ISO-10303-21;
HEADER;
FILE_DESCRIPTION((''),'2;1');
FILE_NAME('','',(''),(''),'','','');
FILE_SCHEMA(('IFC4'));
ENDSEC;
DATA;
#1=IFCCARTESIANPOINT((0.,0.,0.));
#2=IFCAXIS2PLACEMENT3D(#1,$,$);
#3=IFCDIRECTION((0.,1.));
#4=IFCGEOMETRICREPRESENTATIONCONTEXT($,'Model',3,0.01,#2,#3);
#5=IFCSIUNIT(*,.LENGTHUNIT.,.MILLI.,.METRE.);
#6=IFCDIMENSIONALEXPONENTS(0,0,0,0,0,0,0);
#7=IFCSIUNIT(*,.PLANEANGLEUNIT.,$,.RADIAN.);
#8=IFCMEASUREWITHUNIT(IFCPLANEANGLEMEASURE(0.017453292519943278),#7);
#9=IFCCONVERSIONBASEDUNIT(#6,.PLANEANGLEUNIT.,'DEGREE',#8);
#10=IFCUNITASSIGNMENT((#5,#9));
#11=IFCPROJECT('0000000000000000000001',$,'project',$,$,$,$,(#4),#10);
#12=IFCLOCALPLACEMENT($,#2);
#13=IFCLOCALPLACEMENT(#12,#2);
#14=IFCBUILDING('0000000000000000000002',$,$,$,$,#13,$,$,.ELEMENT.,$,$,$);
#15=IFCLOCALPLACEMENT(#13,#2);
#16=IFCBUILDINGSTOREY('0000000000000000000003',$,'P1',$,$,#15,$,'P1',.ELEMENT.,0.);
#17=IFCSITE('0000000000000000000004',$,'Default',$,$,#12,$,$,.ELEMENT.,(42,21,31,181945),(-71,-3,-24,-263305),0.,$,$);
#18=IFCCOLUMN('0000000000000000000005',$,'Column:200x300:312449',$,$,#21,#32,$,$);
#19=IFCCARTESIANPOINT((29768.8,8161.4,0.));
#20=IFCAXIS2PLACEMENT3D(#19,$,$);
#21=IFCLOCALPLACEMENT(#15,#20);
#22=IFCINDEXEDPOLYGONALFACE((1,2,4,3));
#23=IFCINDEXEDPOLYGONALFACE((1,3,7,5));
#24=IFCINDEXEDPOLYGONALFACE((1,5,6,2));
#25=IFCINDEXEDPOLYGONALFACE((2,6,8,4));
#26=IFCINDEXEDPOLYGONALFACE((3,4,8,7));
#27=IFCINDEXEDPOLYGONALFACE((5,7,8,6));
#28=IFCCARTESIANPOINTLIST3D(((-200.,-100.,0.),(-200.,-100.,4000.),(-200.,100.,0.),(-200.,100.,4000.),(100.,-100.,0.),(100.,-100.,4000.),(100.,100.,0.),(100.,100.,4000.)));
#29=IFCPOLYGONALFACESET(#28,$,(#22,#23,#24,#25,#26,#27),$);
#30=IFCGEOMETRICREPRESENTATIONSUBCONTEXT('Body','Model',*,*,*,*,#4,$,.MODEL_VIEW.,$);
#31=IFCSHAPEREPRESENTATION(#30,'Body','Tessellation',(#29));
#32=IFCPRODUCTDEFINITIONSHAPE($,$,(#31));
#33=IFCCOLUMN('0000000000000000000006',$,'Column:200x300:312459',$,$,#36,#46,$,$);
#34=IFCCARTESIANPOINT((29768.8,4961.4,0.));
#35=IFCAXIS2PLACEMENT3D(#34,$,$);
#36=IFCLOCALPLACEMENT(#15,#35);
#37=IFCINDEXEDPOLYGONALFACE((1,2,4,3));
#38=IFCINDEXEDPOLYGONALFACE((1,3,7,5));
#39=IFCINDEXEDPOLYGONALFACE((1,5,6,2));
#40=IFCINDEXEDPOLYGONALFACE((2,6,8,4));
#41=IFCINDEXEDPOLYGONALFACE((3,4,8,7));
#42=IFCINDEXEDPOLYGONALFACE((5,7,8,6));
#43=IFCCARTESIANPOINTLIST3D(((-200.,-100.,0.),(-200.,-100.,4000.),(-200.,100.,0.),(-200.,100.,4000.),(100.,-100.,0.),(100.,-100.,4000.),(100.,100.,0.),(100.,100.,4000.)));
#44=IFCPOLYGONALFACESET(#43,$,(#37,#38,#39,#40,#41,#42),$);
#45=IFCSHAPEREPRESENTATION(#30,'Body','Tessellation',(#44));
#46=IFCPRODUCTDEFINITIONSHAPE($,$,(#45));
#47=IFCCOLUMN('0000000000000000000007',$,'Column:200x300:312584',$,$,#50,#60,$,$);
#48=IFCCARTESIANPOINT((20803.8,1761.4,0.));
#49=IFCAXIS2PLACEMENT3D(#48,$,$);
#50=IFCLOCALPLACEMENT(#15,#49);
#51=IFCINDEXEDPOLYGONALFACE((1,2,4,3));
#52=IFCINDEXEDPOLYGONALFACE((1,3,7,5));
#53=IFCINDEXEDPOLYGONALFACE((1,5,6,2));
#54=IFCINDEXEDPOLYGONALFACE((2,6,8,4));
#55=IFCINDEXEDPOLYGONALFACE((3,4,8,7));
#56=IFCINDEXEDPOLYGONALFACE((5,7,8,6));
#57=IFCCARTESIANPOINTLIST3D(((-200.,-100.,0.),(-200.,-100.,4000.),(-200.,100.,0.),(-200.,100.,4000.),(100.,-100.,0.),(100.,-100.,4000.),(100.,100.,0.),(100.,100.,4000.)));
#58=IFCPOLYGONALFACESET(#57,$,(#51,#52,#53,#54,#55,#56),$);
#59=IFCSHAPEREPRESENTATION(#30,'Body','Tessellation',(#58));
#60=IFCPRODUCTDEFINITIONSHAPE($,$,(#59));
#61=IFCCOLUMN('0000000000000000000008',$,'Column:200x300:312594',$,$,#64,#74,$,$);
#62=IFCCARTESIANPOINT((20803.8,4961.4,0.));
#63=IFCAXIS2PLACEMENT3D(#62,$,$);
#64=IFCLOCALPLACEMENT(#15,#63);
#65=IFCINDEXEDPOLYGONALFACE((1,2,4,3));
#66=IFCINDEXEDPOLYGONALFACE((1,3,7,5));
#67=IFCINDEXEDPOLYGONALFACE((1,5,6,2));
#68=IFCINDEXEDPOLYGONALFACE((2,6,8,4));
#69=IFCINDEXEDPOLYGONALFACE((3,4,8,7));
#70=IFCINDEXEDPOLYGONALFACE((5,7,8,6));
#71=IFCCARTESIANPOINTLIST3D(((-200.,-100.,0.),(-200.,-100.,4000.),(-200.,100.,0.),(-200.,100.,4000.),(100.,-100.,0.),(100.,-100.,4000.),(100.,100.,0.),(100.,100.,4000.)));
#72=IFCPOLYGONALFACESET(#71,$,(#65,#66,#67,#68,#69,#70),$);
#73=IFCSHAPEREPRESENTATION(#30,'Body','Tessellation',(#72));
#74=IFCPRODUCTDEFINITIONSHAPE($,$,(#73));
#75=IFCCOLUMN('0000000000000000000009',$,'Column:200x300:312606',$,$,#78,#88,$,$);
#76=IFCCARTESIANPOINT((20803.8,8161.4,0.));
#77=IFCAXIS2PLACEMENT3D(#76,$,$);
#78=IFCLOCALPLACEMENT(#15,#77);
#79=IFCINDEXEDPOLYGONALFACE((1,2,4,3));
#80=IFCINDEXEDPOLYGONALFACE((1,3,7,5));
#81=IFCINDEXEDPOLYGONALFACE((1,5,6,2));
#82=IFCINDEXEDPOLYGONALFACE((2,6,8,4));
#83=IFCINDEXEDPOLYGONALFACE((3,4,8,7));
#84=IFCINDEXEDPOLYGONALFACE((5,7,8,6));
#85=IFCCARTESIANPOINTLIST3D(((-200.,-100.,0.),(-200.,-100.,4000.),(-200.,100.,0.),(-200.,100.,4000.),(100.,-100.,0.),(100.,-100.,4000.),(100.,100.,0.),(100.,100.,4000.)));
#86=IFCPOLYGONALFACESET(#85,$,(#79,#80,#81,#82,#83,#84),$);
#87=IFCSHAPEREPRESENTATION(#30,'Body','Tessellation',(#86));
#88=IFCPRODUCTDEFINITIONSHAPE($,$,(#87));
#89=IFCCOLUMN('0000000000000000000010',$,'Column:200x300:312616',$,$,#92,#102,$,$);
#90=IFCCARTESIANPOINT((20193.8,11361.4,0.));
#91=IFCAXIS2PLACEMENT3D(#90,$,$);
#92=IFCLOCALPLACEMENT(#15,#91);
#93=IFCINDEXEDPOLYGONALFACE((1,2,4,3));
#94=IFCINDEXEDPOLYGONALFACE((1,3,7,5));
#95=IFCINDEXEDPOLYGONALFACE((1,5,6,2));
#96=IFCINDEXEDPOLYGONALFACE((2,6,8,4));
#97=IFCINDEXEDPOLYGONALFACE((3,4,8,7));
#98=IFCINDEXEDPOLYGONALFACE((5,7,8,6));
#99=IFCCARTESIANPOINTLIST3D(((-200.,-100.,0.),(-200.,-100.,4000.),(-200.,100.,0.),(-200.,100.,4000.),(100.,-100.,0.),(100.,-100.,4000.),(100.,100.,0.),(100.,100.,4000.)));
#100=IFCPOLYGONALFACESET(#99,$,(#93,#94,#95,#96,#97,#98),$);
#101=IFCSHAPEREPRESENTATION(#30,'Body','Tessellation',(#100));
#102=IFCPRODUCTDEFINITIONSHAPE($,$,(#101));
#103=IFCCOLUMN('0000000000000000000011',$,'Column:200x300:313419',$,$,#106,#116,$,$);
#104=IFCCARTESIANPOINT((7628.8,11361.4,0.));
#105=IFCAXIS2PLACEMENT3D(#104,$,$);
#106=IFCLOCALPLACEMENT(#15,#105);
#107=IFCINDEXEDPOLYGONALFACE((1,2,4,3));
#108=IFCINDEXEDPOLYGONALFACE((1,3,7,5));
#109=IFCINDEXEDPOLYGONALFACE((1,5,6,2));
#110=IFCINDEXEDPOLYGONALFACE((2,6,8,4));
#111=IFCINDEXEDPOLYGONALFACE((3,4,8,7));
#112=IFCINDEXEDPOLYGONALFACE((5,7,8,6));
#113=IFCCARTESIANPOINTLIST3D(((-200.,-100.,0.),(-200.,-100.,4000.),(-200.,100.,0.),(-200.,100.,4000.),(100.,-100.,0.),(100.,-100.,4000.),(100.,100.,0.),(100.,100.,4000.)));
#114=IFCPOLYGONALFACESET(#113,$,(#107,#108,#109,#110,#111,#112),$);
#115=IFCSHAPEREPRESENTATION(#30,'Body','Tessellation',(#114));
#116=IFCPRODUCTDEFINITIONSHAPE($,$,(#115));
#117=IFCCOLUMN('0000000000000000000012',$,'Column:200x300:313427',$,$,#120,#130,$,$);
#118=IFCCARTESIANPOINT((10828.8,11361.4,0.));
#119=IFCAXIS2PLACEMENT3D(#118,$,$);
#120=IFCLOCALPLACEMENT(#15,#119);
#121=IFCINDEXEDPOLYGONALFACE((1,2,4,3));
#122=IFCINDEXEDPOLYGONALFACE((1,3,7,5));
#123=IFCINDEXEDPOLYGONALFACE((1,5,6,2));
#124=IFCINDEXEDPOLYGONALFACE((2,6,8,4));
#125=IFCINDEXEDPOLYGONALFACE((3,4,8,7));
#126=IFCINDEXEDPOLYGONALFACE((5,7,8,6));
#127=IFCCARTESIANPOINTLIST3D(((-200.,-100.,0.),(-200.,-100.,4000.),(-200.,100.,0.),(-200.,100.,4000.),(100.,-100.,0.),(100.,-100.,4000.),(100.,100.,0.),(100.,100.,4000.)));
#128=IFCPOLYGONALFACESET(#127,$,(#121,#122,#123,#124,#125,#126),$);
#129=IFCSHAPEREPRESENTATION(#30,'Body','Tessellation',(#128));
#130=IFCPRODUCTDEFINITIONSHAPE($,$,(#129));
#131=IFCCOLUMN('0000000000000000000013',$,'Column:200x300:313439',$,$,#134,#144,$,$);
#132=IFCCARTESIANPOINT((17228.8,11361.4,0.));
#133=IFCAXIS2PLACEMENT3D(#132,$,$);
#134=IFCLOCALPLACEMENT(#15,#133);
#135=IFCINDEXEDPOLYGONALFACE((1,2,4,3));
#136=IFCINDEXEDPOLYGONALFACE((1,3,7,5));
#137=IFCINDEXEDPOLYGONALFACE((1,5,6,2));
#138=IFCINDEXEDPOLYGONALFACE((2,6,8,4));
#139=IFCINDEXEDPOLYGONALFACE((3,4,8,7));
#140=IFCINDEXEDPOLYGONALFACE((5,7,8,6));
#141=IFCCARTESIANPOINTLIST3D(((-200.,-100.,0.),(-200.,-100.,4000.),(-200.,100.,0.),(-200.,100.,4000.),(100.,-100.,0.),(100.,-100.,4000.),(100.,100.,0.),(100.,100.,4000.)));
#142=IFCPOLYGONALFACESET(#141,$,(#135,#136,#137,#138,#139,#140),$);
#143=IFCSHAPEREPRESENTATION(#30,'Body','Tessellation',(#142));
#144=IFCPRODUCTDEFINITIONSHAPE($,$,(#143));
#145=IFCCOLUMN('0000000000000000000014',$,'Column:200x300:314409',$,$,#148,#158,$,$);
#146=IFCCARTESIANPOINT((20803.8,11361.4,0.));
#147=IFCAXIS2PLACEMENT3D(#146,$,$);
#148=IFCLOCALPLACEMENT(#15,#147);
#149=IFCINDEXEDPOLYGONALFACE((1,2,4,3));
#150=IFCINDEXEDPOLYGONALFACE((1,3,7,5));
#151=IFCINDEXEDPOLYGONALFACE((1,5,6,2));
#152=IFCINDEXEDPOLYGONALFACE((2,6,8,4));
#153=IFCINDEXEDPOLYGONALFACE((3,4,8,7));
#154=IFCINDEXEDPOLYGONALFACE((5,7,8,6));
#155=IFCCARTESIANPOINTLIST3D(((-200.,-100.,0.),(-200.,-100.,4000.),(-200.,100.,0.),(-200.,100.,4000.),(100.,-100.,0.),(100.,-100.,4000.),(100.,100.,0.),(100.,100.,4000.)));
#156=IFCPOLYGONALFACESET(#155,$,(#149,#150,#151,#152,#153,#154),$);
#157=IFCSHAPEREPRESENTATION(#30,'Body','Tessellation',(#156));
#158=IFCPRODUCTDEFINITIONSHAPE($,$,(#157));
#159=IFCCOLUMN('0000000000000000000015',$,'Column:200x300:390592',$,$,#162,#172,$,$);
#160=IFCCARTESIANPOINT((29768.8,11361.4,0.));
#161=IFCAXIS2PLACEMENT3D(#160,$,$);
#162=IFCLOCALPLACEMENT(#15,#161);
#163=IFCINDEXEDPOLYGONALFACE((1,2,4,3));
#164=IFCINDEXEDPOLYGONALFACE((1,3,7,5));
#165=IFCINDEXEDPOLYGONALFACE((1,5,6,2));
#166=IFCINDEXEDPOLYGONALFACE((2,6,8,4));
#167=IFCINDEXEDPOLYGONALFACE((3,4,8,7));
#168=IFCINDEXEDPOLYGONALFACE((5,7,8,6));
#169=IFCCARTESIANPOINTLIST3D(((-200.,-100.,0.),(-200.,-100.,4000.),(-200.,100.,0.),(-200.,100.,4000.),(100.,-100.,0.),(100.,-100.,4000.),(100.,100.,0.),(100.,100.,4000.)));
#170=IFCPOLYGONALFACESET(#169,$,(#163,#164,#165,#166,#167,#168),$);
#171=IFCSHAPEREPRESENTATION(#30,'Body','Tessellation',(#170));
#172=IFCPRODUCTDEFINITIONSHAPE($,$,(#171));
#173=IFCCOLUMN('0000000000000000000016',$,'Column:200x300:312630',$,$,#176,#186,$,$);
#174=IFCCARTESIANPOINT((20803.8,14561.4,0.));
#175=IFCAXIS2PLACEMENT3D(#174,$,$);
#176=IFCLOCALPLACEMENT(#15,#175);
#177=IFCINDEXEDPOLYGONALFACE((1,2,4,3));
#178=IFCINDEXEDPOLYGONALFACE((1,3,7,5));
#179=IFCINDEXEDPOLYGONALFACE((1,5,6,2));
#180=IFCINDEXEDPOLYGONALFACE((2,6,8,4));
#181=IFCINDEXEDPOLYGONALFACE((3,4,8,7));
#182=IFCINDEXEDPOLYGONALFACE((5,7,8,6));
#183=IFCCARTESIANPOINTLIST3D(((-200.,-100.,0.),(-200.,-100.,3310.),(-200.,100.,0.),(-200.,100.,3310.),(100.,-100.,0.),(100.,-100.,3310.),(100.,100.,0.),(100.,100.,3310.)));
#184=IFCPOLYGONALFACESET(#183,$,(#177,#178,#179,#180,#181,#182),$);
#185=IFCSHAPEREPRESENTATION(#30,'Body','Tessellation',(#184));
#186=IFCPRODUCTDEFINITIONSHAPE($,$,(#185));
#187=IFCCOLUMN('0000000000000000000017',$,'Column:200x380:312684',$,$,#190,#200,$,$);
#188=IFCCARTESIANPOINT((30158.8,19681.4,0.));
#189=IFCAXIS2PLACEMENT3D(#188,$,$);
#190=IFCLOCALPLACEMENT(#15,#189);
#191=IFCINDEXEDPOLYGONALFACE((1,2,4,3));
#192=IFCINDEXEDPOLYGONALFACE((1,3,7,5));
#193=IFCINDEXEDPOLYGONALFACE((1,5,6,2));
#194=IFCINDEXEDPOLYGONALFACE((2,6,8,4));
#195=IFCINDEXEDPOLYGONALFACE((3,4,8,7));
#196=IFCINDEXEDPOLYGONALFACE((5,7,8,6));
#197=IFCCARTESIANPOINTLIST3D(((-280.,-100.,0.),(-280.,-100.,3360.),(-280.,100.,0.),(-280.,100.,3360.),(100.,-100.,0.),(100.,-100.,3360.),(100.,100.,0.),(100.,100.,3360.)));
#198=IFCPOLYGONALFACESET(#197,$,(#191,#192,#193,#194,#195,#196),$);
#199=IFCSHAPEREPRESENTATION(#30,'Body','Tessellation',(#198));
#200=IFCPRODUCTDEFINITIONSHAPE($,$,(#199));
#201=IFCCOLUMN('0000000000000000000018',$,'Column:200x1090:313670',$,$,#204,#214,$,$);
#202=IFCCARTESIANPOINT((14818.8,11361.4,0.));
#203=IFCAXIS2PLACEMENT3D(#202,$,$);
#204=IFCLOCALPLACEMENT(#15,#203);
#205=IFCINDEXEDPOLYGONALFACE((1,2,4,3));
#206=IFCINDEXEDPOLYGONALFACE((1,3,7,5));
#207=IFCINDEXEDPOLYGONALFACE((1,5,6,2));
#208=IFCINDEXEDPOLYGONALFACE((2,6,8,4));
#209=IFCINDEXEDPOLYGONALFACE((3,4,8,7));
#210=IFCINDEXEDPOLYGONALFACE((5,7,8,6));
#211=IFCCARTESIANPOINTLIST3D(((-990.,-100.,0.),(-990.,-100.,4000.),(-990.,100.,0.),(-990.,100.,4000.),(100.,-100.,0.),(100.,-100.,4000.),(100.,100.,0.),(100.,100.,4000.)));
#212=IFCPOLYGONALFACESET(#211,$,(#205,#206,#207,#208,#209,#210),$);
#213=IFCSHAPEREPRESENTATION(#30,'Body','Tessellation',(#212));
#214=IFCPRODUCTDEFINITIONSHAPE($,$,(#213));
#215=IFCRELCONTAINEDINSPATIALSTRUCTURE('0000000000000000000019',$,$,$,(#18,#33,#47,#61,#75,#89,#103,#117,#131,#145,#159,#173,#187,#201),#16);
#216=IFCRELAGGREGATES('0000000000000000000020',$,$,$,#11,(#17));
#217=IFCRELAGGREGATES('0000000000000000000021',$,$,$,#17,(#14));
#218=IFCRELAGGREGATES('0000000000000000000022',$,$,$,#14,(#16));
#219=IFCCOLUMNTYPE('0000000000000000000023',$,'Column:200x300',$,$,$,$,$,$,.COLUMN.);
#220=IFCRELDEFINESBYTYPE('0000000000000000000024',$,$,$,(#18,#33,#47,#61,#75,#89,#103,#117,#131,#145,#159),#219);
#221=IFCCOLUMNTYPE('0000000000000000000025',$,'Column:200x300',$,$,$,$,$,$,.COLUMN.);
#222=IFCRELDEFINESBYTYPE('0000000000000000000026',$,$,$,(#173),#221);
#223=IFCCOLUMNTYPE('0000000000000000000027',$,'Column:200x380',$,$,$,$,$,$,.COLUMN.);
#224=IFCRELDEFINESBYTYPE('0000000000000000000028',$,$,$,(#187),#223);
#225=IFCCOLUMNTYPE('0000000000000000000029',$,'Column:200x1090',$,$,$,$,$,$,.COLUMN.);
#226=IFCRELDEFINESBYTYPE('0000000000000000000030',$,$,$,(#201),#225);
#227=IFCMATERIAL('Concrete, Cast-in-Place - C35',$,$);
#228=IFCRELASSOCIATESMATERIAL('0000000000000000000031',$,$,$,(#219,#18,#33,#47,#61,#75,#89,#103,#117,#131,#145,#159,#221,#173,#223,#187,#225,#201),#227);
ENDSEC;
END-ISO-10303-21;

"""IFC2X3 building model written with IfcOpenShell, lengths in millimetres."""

from ifc_helpers import new_model, entity, si_unit, converted_unit, direction, frame, origin, origin_2d_with_axis, place, context, subcontext, project, spatial, rectangle, extrude, source, transform, mapped, material, type_object, type_shapes, element, save


model = new_model("IFC2X3")

# Units and contexts
model_context = context("Model", 3, precision=0.01, world=origin(), true_north=direction((0.0, 1.0)))
body_context = subcontext(model_context, "Body", "Model", "MODEL_VIEW")
ifc_project = project(units=[si_unit("LENGTHUNIT", "METRE", prefix="MILLI"), converted_unit("PLANEANGLEUNIT", "DEGREE", entity("IfcPlaneAngleMeasure", 0.017453292519943278), si_unit("PLANEANGLEUNIT", "RADIAN"), dimensions=[0, 0, 0, 0, 0, 0, 0])], contexts=[model_context])

# Site, building, storey
site_placement = place(None, origin())
site = spatial("IfcSite", under=ifc_project, at=site_placement, Name="Default", CompositionType="ELEMENT", RefLatitude=(42, 21, 31, 181945), RefLongitude=(-71, -3, -24, -263305), RefElevation=0.0)
building_placement = place(site_placement, origin())
building = spatial("IfcBuilding", under=site, at=building_placement, CompositionType="ELEMENT")
storey_placement = place(building_placement, origin())
storey = spatial("IfcBuildingStorey", under=building, at=storey_placement, Name="P1", LongName="P1", CompositionType="ELEMENT", Elevation=0.0)

# Columns
ifc_material = material(Name="Concrete, Cast-in-Place - C35")
column_type_1 = type_object("IfcColumnType", Name="Column:200x300", PredefinedType="COLUMN", material=ifc_material)
shared_shape_1 = source(origin(), body_context, "Body", "SweptSolid", [
    extrude(rectangle(XDim=300.0, YDim=200.0, at=origin_2d_with_axis()), frame((-50.0, 0.0, 0.0), z_axis=(0.0, 0.0, 1.0), x_axis=(-1.0, 0.0, 0.0)), (0.0, 0.0, 1.0), 4000.0),
])
type_shapes(column_type_1, [shared_shape_1])
for number, where, name in (
    (1, (29768.8, 8161.4, 0.0), "Column:200x300:312449"),
    (2, (29768.8, 4961.4, 0.0), "Column:200x300:312459"),
    (3, (20803.8, 1761.4, 0.0), "Column:200x300:312584"),
    (4, (20803.8, 4961.4, 0.0), "Column:200x300:312594"),
    (5, (20803.8, 8161.4, 0.0), "Column:200x300:312606"),
    (6, (20193.8, 11361.4, 0.0), "Column:200x300:312616"),
    (7, (7628.8, 11361.4, 0.0), "Column:200x300:313419"),
    (8, (10828.8, 11361.4, 0.0), "Column:200x300:313427"),
    (9, (17228.8, 11361.4, 0.0), "Column:200x300:313439"),
    (10, (20803.8, 11361.4, 0.0), "Column:200x300:314409"),
    (11, (29768.8, 11361.4, 0.0), "Column:200x300:390592"),
):
    element("IfcColumn", number, at=place(storey_placement, frame(where)), inside=storey, type_object=column_type_1, material=ifc_material, Name=name, context=body_context, shape_type="MappedRepresentation", body=[
        mapped(shared_shape_1, transform((0.0, 0.0, 0.0), scale=1.0)),
    ])
column_type_2 = type_object("IfcColumnType", Name="Column:200x300", PredefinedType="COLUMN", material=ifc_material)
shared_shape_2 = source(origin(), body_context, "Body", "SweptSolid", [
    extrude(rectangle(XDim=300.0, YDim=200.0, at=origin_2d_with_axis()), frame((-50.0, 0.0, 0.0), z_axis=(0.0, 0.0, 1.0), x_axis=(-1.0, 0.0, 0.0)), (0.0, 0.0, 1.0), 3310.0),
])
type_shapes(column_type_2, [shared_shape_2])
column_1_placement = place(storey_placement, frame((20803.8, 14561.4, 0.0)))
element("IfcColumn", 12, at=column_1_placement, inside=storey, type_object=column_type_2, material=ifc_material, Name="Column:200x300:312630", context=body_context, shape_type="MappedRepresentation", body=[
    mapped(shared_shape_2, transform((0.0, 0.0, 0.0), scale=1.0)),
])
column_type_3 = type_object("IfcColumnType", Name="Column:200x380", PredefinedType="COLUMN", material=ifc_material)
shared_shape_3 = source(origin(), body_context, "Body", "SweptSolid", [
    extrude(rectangle(XDim=380.0, YDim=200.0, at=origin_2d_with_axis()), frame((-90.0, 0.0, 0.0), z_axis=(0.0, 0.0, 1.0), x_axis=(-1.0, 0.0, 0.0)), (0.0, 0.0, 1.0), 3360.0),
])
type_shapes(column_type_3, [shared_shape_3])
column_2_placement = place(storey_placement, frame((30158.8, 19681.4, 0.0)))
element("IfcColumn", 13, at=column_2_placement, inside=storey, type_object=column_type_3, material=ifc_material, Name="Column:200x380:312684", context=body_context, shape_type="MappedRepresentation", body=[
    mapped(shared_shape_3, transform((0.0, 0.0, 0.0), scale=1.0)),
])
column_type_4 = type_object("IfcColumnType", Name="Column:200x1090", PredefinedType="COLUMN", material=ifc_material)
shared_shape_4 = source(origin(), body_context, "Body", "SweptSolid", [
    extrude(rectangle(XDim=1090.0, YDim=200.0, at=origin_2d_with_axis()), frame((-445.0, 0.0, 0.0), z_axis=(0.0, 0.0, 1.0), x_axis=(-1.0, 0.0, 0.0)), (0.0, 0.0, 1.0), 4000.0),
])
type_shapes(column_type_4, [shared_shape_4])
column_3_placement = place(storey_placement, frame((14818.8, 11361.4, 0.0)))
element("IfcColumn", 14, at=column_3_placement, inside=storey, type_object=column_type_4, material=ifc_material, Name="Column:200x1090:313670", context=body_context, shape_type="MappedRepresentation", body=[
    mapped(shared_shape_4, transform((0.0, 0.0, 0.0), scale=1.0)),
])

save(model, "model.ifc")
